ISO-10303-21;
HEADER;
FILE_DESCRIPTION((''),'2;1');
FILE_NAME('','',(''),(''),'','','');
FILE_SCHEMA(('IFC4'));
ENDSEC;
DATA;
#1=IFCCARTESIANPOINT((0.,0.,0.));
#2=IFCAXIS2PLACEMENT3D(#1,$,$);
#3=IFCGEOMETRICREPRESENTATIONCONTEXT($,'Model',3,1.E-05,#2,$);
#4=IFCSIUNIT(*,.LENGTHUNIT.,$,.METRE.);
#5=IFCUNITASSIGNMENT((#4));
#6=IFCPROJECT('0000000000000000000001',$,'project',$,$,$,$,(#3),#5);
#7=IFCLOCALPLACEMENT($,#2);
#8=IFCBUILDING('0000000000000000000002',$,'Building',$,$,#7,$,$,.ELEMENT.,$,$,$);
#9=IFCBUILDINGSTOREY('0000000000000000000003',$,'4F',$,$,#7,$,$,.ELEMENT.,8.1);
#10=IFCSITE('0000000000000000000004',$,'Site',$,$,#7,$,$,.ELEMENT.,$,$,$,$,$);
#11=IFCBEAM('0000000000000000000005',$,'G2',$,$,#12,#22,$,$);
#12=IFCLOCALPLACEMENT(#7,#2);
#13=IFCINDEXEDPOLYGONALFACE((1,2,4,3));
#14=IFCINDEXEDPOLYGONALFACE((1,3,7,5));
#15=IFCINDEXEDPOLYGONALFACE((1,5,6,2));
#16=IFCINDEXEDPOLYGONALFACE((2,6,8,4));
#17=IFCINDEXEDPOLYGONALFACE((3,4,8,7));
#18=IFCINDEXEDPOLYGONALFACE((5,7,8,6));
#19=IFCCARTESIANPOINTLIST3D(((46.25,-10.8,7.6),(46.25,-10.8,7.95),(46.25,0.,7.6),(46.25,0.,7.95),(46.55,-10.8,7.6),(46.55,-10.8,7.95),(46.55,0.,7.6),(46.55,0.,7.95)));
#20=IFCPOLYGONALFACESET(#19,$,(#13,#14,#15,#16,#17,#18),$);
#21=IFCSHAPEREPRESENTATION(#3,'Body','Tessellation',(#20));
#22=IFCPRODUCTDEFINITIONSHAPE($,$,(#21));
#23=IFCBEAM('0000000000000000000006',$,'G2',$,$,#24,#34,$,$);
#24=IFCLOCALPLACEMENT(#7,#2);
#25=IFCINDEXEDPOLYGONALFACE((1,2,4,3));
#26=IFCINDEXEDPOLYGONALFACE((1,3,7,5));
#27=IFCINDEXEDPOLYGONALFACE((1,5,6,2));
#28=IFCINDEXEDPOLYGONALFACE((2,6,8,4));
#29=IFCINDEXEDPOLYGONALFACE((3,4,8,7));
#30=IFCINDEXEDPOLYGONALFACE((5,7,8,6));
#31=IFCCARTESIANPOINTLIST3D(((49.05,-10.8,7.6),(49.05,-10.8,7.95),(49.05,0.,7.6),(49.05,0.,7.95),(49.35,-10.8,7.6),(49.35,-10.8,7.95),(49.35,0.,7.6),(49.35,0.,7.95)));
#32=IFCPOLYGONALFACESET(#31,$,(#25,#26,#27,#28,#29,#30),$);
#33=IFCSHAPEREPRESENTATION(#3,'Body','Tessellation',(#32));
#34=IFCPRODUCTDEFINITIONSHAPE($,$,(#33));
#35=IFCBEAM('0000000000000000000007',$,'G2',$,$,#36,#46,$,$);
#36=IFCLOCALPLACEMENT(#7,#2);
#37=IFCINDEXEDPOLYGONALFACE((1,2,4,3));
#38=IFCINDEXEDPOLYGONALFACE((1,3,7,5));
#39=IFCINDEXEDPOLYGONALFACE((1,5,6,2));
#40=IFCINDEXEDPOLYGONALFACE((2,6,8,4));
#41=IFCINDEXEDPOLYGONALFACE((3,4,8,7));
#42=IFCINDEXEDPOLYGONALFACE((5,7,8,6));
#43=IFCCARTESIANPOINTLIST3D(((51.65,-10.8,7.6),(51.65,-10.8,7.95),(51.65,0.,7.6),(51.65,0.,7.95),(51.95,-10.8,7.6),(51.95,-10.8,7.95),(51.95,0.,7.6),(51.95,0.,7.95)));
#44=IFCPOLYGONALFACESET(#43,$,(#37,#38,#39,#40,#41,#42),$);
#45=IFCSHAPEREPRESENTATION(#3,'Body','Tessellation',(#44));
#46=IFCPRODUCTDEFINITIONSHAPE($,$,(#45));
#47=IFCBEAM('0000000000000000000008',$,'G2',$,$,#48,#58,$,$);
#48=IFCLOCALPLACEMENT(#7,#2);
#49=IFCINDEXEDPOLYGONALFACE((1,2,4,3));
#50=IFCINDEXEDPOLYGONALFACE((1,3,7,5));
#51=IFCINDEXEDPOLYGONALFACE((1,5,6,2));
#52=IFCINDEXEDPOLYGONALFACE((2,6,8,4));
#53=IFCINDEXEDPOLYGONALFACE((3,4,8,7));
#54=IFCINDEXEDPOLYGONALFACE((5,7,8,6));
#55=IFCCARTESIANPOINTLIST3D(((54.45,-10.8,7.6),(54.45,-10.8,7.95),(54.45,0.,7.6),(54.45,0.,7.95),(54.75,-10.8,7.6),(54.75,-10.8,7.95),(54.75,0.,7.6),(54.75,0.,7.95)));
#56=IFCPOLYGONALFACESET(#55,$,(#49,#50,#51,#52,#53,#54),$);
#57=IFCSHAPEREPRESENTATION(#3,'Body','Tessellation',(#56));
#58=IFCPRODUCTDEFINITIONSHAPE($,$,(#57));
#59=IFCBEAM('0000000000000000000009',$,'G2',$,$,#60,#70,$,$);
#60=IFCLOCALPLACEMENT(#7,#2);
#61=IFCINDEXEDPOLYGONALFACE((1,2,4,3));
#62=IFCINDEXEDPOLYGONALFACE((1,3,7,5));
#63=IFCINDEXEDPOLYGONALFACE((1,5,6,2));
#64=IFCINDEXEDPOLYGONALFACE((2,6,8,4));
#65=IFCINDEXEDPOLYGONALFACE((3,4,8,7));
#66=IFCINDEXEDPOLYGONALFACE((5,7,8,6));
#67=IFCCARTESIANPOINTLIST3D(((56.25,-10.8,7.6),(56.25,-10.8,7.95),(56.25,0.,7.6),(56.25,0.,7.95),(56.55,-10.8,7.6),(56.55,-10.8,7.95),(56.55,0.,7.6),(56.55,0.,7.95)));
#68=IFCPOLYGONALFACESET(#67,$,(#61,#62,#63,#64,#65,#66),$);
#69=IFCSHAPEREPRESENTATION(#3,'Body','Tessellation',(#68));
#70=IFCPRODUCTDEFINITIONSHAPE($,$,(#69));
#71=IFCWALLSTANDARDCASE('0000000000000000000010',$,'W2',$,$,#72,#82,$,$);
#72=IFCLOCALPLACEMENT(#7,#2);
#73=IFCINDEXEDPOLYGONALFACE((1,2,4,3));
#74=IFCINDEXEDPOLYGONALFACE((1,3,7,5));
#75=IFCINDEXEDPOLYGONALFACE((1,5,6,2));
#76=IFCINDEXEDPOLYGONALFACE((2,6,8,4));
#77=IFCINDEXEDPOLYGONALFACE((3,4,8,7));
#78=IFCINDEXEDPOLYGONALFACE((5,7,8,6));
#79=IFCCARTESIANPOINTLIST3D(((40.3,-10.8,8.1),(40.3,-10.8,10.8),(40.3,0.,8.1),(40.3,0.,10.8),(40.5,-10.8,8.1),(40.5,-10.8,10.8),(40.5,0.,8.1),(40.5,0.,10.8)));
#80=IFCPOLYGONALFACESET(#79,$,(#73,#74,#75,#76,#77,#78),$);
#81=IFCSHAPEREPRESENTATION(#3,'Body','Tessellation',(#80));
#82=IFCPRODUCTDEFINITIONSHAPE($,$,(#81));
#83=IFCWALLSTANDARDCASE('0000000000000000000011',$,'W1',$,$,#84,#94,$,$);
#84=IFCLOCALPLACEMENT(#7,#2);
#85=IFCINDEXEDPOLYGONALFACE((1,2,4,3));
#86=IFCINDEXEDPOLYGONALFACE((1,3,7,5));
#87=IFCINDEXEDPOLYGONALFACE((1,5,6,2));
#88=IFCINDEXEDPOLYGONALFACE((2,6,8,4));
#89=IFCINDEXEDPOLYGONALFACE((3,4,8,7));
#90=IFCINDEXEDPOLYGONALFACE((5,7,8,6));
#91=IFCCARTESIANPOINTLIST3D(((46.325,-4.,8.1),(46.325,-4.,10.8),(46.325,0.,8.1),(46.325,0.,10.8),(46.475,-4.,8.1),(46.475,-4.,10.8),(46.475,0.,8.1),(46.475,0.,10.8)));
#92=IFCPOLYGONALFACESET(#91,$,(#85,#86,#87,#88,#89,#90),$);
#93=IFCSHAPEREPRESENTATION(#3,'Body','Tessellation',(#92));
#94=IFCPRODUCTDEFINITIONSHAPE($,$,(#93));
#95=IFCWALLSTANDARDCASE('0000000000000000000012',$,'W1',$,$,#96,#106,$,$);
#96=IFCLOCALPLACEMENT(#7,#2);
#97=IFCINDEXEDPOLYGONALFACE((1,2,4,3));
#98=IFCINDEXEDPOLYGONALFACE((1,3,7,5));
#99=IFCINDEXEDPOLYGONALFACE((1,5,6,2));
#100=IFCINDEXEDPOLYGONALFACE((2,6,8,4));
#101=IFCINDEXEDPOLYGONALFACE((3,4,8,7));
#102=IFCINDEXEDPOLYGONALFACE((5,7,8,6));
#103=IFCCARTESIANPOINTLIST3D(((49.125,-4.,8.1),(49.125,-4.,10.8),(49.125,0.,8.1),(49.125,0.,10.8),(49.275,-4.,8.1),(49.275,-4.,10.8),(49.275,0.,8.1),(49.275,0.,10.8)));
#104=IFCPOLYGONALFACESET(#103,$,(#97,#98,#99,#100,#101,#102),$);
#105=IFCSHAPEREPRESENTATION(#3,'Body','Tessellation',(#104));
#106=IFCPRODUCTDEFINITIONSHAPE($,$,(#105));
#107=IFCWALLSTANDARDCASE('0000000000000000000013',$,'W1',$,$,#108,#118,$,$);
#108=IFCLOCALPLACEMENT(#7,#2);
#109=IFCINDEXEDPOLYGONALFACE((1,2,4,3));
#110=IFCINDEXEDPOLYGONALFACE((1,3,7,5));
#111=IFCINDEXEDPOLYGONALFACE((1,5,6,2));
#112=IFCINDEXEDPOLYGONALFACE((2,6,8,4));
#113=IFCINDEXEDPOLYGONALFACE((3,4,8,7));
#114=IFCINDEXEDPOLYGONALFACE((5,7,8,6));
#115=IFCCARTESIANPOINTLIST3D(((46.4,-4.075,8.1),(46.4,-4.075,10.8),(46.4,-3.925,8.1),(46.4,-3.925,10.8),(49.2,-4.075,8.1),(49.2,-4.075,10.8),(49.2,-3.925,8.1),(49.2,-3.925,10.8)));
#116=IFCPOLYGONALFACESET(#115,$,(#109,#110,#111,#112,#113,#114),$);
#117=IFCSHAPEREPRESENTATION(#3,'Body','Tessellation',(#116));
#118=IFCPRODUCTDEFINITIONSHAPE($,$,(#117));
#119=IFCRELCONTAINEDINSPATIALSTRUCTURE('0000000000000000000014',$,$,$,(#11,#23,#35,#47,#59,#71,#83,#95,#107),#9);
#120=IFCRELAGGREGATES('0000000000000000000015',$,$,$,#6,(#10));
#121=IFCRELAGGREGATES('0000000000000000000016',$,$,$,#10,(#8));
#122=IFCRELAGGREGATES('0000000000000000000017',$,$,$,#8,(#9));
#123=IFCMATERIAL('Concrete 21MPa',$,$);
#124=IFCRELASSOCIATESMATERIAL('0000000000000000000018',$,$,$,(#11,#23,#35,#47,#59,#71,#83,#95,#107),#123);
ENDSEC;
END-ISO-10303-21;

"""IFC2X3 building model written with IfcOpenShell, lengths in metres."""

from ifc_helpers import new_model, si_unit, frame, origin, origin_2d, place, context, project, spatial, rectangle, extrude, material, element, save


model = new_model("IFC2X3")

# Units and contexts
model_context = context("Model", 3, precision=1e-05, world=origin())
ifc_project = project(units=[si_unit("LENGTHUNIT", "METRE")], contexts=[model_context])

# Site, building, storey
placement = place(None, origin())
site = spatial("IfcSite", under=ifc_project, at=placement, Name="Site", CompositionType="ELEMENT")
building = spatial("IfcBuilding", under=site, at=placement, Name="Building", CompositionType="ELEMENT")
storey = spatial("IfcBuildingStorey", under=building, at=placement, Name="4F", CompositionType="ELEMENT", Elevation=8.1)

# Shared definitions
ifc_material = material(Name="Concrete 21MPa")

# Beams
for number, where, name in (
    (1, (46.4, -5.4, 7.6), "G2"),
    (2, (49.2, -5.4, 7.6), "G2"),
    (3, (51.8, -5.4, 7.6), "G2"),
    (4, (54.6, -5.4, 7.6), "G2"),
    (5, (56.4, -5.4, 7.6), "G2"),
):
    element("IfcBeam", number, at=place(None, frame(where)), inside=storey, material=ifc_material, Name=name, context=model_context, shape_type="SweptSolid", body=[
        extrude(rectangle(XDim=0.3, YDim=10.8, at=origin_2d()), origin(), (0.0, 0.0, 1.0), 0.35),
    ])

# Walls
wall_1_placement = place(None, frame((40.4, -5.4, 8.1)))
element("IfcWallStandardCase", 6, at=wall_1_placement, inside=storey, material=ifc_material, Name="W2", context=model_context, shape_type="SweptSolid", body=[
    extrude(rectangle(XDim=0.2, YDim=10.8, at=origin_2d()), origin(), (0.0, 0.0, 1.0), 2.7),
])
for number, where, name in (
    (7, (46.4, -2.0, 8.1), "W1"),
    (8, (49.2, -2.0, 8.1), "W1"),
):
    element("IfcWallStandardCase", number, at=place(None, frame(where)), inside=storey, material=ifc_material, Name=name, context=model_context, shape_type="SweptSolid", body=[
        extrude(rectangle(XDim=0.15, YDim=4.0, at=origin_2d()), origin(), (0.0, 0.0, 1.0), 2.7),
    ])
wall_2_placement = place(None, frame((47.8, -4.0, 8.1)))
element("IfcWallStandardCase", 9, at=wall_2_placement, inside=storey, material=ifc_material, Name="W1", context=model_context, shape_type="SweptSolid", body=[
    extrude(rectangle(XDim=2.8, YDim=0.15, at=origin_2d()), origin(), (0.0, 0.0, 1.0), 2.7),
])

save(model, "model.ifc")
